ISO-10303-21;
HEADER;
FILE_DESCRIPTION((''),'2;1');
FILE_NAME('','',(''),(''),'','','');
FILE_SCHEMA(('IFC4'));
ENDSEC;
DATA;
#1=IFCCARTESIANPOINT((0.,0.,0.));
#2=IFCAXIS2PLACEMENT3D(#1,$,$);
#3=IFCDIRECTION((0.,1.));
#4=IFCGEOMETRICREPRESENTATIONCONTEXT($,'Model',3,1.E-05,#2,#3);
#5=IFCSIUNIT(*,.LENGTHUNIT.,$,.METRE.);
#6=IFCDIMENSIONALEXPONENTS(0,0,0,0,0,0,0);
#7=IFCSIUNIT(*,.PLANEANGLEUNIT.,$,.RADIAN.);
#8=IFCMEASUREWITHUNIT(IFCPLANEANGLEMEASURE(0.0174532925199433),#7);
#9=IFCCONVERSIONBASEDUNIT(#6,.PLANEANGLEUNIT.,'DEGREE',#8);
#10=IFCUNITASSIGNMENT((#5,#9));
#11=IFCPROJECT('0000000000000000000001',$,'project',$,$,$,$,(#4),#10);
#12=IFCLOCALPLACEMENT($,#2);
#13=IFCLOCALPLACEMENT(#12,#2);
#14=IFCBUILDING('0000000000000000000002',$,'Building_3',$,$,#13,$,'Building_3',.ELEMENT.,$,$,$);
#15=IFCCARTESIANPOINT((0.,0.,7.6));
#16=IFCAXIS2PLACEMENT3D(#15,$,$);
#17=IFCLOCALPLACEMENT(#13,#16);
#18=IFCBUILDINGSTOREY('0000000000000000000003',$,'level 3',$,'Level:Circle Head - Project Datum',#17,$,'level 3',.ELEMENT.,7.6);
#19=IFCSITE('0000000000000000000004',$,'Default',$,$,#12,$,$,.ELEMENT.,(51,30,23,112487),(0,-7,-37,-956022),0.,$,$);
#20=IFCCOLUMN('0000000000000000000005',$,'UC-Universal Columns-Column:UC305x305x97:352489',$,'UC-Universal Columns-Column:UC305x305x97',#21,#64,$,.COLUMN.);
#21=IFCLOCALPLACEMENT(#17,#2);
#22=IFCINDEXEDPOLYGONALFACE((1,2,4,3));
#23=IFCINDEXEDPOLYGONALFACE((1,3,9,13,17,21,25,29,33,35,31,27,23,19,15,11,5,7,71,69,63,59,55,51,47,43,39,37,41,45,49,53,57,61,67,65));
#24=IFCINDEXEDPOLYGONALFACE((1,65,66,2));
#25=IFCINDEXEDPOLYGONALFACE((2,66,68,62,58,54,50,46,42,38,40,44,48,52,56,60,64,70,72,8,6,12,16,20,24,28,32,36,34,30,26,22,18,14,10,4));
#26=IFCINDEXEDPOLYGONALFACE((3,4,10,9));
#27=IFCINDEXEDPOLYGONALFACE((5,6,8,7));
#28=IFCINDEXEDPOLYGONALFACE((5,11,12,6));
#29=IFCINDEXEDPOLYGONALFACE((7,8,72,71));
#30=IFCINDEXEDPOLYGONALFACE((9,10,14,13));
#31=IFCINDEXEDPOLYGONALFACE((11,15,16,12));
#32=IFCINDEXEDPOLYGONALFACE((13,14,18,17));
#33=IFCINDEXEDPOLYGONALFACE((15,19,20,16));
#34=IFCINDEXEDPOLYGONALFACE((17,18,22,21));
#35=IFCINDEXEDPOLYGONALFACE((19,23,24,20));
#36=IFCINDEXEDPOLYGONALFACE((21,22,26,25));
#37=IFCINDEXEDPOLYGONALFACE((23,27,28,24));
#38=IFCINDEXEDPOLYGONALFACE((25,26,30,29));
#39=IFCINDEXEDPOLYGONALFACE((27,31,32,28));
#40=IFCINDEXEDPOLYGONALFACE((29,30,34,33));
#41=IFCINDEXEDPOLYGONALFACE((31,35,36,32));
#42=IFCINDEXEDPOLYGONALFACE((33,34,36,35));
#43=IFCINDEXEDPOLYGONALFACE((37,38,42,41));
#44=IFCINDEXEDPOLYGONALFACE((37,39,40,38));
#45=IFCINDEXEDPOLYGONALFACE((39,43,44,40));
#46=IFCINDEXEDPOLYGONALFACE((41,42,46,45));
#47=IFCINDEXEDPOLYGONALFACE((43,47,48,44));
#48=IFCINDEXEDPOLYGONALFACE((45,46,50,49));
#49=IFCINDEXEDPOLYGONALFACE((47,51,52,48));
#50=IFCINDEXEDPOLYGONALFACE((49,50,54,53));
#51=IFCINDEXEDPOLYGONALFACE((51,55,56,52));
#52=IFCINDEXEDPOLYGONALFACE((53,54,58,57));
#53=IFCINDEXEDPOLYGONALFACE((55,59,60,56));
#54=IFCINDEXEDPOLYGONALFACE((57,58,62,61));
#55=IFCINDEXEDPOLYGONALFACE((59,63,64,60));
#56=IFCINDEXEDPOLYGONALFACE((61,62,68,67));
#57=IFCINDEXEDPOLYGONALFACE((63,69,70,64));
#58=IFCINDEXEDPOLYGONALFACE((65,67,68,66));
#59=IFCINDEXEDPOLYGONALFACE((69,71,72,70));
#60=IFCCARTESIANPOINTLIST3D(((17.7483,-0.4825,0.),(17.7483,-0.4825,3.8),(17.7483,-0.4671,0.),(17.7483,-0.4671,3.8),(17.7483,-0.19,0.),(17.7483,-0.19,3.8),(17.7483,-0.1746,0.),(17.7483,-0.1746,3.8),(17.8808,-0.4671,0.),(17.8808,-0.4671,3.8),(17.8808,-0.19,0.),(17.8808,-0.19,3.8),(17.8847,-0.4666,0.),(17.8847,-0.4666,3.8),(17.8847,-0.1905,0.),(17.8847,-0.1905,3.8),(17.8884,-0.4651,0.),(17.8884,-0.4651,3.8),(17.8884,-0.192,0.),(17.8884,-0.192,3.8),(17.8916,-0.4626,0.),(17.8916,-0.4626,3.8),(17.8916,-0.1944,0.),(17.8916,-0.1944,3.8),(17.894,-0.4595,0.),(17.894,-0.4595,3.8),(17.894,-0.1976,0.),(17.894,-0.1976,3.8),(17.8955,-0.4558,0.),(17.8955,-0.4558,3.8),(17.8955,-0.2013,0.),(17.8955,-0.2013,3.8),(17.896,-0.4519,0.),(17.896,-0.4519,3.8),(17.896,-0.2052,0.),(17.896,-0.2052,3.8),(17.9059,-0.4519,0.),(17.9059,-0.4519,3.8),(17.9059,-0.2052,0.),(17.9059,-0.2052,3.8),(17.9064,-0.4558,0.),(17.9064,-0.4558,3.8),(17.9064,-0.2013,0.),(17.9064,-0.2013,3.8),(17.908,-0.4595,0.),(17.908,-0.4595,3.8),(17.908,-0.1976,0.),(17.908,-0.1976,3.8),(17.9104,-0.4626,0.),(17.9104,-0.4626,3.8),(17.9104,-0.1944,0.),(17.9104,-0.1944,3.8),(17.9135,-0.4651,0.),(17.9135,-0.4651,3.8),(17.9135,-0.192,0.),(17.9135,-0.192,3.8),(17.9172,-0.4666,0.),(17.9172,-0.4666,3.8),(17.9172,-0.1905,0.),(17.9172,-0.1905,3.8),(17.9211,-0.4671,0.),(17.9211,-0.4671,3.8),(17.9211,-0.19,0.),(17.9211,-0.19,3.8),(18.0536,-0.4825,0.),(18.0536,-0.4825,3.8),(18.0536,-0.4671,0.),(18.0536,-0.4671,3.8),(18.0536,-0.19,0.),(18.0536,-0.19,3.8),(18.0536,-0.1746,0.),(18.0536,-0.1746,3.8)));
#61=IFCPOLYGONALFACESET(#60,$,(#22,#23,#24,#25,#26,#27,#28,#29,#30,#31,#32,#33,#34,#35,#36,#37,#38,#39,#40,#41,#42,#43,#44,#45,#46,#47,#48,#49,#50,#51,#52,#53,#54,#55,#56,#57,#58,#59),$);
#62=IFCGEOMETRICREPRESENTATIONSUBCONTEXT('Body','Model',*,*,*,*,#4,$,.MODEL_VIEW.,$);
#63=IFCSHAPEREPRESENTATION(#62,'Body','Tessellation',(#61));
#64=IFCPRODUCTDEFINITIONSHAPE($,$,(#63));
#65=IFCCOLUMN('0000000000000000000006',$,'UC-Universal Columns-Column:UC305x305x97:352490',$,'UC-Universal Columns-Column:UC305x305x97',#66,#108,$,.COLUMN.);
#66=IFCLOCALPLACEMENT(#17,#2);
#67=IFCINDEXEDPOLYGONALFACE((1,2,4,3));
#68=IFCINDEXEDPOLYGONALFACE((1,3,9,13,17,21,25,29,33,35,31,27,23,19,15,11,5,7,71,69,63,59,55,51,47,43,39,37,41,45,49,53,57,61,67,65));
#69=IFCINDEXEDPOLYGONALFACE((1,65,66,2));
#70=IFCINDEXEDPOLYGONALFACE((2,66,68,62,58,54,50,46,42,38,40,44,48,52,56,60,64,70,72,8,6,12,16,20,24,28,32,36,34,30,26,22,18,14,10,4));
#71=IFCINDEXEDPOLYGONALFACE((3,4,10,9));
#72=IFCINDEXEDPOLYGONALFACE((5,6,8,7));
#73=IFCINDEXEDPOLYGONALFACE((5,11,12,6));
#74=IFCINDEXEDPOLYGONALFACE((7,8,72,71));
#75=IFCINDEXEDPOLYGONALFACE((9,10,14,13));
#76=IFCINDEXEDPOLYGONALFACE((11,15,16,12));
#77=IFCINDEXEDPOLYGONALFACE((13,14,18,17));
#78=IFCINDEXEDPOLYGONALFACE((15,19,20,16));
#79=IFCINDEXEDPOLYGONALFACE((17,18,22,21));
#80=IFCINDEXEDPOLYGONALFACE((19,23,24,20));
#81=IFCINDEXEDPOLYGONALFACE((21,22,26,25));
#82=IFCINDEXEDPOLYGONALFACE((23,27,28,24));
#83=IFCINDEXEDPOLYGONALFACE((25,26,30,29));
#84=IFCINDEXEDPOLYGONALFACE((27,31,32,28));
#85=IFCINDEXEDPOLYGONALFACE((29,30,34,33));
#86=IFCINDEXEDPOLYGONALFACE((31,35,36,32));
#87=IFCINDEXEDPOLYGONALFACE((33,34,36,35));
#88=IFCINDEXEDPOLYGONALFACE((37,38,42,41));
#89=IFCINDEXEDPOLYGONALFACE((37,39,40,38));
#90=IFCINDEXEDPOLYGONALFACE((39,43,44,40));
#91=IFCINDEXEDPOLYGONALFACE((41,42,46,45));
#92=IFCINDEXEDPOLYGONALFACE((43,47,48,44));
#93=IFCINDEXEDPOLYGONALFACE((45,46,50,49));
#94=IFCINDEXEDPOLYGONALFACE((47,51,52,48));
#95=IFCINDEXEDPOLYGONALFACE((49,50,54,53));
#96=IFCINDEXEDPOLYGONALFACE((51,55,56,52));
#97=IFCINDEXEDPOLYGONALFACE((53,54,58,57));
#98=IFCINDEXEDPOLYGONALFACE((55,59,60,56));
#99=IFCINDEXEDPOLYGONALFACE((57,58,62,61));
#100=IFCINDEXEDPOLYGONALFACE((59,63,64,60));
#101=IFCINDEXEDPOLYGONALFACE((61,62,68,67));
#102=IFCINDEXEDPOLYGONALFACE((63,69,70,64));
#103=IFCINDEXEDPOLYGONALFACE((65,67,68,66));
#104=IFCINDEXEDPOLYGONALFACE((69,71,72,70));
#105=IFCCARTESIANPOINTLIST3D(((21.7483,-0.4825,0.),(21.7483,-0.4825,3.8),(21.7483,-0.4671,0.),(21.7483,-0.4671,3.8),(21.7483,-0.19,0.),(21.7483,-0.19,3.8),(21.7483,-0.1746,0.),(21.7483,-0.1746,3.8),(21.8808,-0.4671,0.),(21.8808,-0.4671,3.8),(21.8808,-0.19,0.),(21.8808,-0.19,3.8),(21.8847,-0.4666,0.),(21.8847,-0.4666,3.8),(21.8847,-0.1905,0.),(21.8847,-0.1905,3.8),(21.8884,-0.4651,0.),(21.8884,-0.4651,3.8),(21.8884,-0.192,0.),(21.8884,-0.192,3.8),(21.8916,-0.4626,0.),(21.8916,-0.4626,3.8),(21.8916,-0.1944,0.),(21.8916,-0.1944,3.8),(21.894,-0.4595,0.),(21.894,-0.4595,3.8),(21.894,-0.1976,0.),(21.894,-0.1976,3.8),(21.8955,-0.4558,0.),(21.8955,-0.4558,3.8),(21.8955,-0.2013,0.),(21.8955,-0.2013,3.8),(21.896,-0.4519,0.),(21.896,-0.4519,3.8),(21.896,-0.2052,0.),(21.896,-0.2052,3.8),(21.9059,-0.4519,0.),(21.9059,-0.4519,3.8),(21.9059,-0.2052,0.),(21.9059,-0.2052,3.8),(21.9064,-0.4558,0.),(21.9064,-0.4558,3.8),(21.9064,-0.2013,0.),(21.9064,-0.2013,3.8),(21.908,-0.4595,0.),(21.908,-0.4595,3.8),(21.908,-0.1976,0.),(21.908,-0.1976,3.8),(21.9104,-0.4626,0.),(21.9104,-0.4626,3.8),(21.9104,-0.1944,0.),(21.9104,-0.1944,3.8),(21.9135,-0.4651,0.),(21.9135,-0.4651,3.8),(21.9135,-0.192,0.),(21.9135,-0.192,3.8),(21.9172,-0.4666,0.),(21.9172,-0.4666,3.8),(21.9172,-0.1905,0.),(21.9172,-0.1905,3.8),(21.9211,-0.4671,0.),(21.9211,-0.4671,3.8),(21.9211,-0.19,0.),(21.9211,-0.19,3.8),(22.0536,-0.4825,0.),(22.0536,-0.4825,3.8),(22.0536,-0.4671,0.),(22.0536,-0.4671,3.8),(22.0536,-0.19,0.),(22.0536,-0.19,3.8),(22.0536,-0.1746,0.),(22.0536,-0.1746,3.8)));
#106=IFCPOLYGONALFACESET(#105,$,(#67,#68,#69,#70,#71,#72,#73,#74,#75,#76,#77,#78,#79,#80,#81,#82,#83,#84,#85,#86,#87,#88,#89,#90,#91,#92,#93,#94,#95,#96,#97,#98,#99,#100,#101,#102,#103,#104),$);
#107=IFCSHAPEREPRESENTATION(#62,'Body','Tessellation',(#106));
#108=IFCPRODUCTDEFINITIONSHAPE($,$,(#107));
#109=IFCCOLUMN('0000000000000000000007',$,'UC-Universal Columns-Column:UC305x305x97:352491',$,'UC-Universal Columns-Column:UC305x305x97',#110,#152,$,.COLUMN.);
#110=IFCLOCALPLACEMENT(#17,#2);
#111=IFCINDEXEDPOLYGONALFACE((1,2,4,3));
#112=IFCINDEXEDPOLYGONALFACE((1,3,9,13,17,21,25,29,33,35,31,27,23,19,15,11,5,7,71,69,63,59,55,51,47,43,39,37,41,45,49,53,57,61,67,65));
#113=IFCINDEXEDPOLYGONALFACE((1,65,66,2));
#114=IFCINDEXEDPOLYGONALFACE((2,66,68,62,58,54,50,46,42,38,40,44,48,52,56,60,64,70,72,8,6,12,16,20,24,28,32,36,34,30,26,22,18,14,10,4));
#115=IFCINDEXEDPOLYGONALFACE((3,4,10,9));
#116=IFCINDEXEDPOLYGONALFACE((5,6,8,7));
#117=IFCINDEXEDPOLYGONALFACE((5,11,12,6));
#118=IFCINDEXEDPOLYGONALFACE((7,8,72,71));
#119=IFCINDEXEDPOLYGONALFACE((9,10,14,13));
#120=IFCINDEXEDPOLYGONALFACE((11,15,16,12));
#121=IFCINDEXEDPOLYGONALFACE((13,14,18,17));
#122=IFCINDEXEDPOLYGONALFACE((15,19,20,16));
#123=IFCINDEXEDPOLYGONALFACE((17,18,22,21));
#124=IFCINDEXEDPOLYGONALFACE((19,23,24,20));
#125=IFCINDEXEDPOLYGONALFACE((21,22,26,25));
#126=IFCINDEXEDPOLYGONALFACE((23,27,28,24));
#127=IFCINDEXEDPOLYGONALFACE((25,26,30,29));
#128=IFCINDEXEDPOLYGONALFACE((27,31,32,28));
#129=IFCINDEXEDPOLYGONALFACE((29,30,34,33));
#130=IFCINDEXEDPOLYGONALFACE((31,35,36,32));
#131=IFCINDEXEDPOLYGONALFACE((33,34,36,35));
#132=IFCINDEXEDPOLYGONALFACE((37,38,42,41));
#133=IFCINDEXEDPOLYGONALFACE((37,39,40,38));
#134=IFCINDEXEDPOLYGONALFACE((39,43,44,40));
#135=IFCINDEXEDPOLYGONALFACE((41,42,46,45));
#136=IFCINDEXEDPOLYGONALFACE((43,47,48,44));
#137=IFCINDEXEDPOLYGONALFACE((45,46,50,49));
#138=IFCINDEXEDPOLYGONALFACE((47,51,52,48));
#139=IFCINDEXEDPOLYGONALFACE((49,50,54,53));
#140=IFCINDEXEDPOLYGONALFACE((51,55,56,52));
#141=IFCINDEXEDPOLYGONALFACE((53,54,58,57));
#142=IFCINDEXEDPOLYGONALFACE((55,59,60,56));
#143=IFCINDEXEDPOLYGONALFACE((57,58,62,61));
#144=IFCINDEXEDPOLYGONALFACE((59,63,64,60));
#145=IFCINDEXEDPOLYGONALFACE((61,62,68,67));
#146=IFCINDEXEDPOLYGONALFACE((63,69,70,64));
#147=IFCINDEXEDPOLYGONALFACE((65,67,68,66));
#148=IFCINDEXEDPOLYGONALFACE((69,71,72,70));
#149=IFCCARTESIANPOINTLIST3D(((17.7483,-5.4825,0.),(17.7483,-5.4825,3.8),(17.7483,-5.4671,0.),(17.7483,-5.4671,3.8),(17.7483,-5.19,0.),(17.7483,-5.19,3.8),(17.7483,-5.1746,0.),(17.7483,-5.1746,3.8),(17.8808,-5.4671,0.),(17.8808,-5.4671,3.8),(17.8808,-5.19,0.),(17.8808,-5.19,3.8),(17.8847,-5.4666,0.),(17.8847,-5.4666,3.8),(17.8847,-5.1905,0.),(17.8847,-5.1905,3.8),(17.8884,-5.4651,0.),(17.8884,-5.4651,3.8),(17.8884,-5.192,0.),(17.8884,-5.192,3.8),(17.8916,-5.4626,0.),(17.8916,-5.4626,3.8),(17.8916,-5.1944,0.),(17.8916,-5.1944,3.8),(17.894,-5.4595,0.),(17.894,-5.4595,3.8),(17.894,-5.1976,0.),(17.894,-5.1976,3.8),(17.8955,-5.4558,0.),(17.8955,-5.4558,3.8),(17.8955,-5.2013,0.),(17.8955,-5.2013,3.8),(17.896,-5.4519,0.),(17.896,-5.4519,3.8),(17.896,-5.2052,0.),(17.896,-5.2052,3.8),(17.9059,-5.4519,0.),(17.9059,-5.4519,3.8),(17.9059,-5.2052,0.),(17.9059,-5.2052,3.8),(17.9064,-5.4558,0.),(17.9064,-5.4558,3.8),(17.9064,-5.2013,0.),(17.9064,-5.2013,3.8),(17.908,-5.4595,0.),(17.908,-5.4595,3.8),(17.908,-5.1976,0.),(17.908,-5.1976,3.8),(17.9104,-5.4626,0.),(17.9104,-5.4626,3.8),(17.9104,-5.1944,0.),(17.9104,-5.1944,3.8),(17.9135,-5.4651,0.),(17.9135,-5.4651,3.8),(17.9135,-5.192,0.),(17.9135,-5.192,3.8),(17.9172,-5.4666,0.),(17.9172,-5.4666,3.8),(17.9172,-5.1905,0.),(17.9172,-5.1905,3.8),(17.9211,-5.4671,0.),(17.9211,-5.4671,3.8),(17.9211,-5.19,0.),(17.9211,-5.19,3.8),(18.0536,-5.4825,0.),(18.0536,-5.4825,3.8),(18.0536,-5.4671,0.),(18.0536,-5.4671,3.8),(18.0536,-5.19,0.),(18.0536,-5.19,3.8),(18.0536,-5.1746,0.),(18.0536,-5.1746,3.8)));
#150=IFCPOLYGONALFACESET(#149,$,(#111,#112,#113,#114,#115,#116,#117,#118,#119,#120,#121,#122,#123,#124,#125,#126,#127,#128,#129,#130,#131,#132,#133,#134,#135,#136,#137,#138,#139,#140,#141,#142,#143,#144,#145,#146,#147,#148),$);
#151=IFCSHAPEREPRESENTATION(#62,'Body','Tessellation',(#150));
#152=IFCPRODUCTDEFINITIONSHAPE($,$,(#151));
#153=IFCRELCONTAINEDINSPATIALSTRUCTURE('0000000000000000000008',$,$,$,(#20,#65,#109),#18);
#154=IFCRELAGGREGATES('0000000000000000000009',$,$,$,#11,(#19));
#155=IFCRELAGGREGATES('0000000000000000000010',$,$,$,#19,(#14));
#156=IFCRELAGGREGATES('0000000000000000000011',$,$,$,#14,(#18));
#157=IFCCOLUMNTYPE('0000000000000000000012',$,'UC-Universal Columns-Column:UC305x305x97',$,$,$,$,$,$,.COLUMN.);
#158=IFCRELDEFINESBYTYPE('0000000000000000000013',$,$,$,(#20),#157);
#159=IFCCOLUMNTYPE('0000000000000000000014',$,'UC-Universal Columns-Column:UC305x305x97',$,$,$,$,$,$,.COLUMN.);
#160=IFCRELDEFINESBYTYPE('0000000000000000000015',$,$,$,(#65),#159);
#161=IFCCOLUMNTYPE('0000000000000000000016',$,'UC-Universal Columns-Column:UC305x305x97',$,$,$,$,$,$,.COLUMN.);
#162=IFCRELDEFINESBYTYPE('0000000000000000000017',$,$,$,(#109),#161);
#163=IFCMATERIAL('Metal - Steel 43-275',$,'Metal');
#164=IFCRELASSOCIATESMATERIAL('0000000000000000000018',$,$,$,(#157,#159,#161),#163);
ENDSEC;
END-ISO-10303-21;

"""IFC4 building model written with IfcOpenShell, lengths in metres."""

from ifc_helpers import new_model, entity, si_unit, converted_unit, direction, frame, frame_2d, origin, place, context, subcontext, project, spatial, i_section, extrude, source, transform, mapped, material, material_profile, profile_set, type_object, type_shapes, element, save


model = new_model("IFC4")

# Units and contexts
model_context = context("Model", 3, precision=1e-05, world=origin(), true_north=direction((0.0, 1.0)))
body_context = subcontext(model_context, "Body", "Model", "MODEL_VIEW")
ifc_project = project(units=[si_unit("LENGTHUNIT", "METRE"), converted_unit("PLANEANGLEUNIT", "DEGREE", entity("IfcPlaneAngleMeasure", 0.0174532925199433), si_unit("PLANEANGLEUNIT", "RADIAN"), dimensions=[0, 0, 0, 0, 0, 0, 0])], contexts=[model_context])

# Site, building, storey
site_placement = place(None, origin())
site = spatial("IfcSite", under=ifc_project, at=site_placement, Name="Default", CompositionType="ELEMENT", RefLatitude=(51, 30, 23, 112487), RefLongitude=(0, -7, -37, -956022), RefElevation=0.0)
building_placement = place(site_placement, origin())
building = spatial("IfcBuilding", under=site, at=building_placement, Name="Building_3", LongName="Building_3", CompositionType="ELEMENT")
storey_placement = place(building_placement, frame((0.0, 0.0, 7.6)))
storey = spatial("IfcBuildingStorey", under=building, at=storey_placement, Name="level 3", ObjectType="Level:Circle Head - Project Datum", LongName="level 3", CompositionType="ELEMENT", Elevation=7.6)

# Columns
ifc_material_1 = material(Name="Metal - Steel 43-275", Category="Metal")
ifc_material_profile_1 = material_profile(ifc_material_1, i_section(OverallWidth=0.3053, OverallDepth=0.3079, WebThickness=0.0099, FlangeThickness=0.0154, FilletRadius=0.0152, at=frame_2d((0.0, 0.0), x_axis=(1.0, 0.0))), Name="UC305x305x97")
ifc_profile_set_1 = profile_set([ifc_material_profile_1], Name="UC305x305x97")
column_type_1 = type_object("IfcColumnType", Name="UC-Universal Columns-Column:UC305x305x97", PredefinedType="COLUMN", material=ifc_profile_set_1)
shared_shape_1 = source(origin(), body_context, "Body", "SweptSolid", [
    extrude(i_section(OverallWidth=0.3053, OverallDepth=0.3079, WebThickness=0.0099, FlangeThickness=0.0154, FilletRadius=0.0152, at=frame_2d((0.0, 0.0), x_axis=(1.0, 0.0))), frame((17.901, -0.3285, 7.6), z_axis=(0.0, 0.0, 1.0), x_axis=(-1.0, 0.0, 0.0)), (0.0, 0.0, 1.0), 3.8),
])
type_shapes(column_type_1, [shared_shape_1])
column_1_placement = place(storey_placement, frame((0.0, 0.0, -7.6)))
element("IfcColumn", 1, at=column_1_placement, inside=storey, type_object=column_type_1, Name="UC-Universal Columns-Column:UC305x305x97:352489", ObjectType="UC-Universal Columns-Column:UC305x305x97", PredefinedType="COLUMN", context=body_context, shape_type="MappedRepresentation", body=[
    mapped(shared_shape_1, transform((0.0, 0.0, 0.0), scale=1.0)),
])
column_type_2 = type_object("IfcColumnType", Name="UC-Universal Columns-Column:UC305x305x97", PredefinedType="COLUMN", material=ifc_profile_set_1)
shared_shape_2 = source(origin(), body_context, "Body", "SweptSolid", [
    extrude(i_section(OverallWidth=0.3053, OverallDepth=0.3079, WebThickness=0.0099, FlangeThickness=0.0154, FilletRadius=0.0152, at=frame_2d((0.0, 0.0), x_axis=(1.0, 0.0))), frame((21.901, -0.3285, 7.6), z_axis=(0.0, 0.0, 1.0), x_axis=(-1.0, 0.0, 0.0)), (0.0, 0.0, 1.0), 3.8),
])
type_shapes(column_type_2, [shared_shape_2])
column_2_placement = place(storey_placement, frame((0.0, 0.0, -7.6)))
element("IfcColumn", 2, at=column_2_placement, inside=storey, type_object=column_type_2, Name="UC-Universal Columns-Column:UC305x305x97:352490", ObjectType="UC-Universal Columns-Column:UC305x305x97", PredefinedType="COLUMN", context=body_context, shape_type="MappedRepresentation", body=[
    mapped(shared_shape_2, transform((0.0, 0.0, 0.0), scale=1.0)),
])
column_type_3 = type_object("IfcColumnType", Name="UC-Universal Columns-Column:UC305x305x97", PredefinedType="COLUMN", material=ifc_profile_set_1)
shared_shape_3 = source(origin(), body_context, "Body", "SweptSolid", [
    extrude(i_section(OverallWidth=0.3053, OverallDepth=0.3079, WebThickness=0.0099, FlangeThickness=0.0154, FilletRadius=0.0152, at=frame_2d((0.0, 0.0), x_axis=(1.0, 0.0))), frame((17.901, -5.3285, 7.6), z_axis=(0.0, 0.0, 1.0), x_axis=(-1.0, 0.0, 0.0)), (0.0, 0.0, 1.0), 3.8),
])
type_shapes(column_type_3, [shared_shape_3])
column_3_placement = place(storey_placement, frame((0.0, 0.0, -7.6)))
element("IfcColumn", 3, at=column_3_placement, inside=storey, type_object=column_type_3, Name="UC-Universal Columns-Column:UC305x305x97:352491", ObjectType="UC-Universal Columns-Column:UC305x305x97", PredefinedType="COLUMN", context=body_context, shape_type="MappedRepresentation", body=[
    mapped(shared_shape_3, transform((0.0, 0.0, 0.0), scale=1.0)),
])

save(model, "model.ifc")
